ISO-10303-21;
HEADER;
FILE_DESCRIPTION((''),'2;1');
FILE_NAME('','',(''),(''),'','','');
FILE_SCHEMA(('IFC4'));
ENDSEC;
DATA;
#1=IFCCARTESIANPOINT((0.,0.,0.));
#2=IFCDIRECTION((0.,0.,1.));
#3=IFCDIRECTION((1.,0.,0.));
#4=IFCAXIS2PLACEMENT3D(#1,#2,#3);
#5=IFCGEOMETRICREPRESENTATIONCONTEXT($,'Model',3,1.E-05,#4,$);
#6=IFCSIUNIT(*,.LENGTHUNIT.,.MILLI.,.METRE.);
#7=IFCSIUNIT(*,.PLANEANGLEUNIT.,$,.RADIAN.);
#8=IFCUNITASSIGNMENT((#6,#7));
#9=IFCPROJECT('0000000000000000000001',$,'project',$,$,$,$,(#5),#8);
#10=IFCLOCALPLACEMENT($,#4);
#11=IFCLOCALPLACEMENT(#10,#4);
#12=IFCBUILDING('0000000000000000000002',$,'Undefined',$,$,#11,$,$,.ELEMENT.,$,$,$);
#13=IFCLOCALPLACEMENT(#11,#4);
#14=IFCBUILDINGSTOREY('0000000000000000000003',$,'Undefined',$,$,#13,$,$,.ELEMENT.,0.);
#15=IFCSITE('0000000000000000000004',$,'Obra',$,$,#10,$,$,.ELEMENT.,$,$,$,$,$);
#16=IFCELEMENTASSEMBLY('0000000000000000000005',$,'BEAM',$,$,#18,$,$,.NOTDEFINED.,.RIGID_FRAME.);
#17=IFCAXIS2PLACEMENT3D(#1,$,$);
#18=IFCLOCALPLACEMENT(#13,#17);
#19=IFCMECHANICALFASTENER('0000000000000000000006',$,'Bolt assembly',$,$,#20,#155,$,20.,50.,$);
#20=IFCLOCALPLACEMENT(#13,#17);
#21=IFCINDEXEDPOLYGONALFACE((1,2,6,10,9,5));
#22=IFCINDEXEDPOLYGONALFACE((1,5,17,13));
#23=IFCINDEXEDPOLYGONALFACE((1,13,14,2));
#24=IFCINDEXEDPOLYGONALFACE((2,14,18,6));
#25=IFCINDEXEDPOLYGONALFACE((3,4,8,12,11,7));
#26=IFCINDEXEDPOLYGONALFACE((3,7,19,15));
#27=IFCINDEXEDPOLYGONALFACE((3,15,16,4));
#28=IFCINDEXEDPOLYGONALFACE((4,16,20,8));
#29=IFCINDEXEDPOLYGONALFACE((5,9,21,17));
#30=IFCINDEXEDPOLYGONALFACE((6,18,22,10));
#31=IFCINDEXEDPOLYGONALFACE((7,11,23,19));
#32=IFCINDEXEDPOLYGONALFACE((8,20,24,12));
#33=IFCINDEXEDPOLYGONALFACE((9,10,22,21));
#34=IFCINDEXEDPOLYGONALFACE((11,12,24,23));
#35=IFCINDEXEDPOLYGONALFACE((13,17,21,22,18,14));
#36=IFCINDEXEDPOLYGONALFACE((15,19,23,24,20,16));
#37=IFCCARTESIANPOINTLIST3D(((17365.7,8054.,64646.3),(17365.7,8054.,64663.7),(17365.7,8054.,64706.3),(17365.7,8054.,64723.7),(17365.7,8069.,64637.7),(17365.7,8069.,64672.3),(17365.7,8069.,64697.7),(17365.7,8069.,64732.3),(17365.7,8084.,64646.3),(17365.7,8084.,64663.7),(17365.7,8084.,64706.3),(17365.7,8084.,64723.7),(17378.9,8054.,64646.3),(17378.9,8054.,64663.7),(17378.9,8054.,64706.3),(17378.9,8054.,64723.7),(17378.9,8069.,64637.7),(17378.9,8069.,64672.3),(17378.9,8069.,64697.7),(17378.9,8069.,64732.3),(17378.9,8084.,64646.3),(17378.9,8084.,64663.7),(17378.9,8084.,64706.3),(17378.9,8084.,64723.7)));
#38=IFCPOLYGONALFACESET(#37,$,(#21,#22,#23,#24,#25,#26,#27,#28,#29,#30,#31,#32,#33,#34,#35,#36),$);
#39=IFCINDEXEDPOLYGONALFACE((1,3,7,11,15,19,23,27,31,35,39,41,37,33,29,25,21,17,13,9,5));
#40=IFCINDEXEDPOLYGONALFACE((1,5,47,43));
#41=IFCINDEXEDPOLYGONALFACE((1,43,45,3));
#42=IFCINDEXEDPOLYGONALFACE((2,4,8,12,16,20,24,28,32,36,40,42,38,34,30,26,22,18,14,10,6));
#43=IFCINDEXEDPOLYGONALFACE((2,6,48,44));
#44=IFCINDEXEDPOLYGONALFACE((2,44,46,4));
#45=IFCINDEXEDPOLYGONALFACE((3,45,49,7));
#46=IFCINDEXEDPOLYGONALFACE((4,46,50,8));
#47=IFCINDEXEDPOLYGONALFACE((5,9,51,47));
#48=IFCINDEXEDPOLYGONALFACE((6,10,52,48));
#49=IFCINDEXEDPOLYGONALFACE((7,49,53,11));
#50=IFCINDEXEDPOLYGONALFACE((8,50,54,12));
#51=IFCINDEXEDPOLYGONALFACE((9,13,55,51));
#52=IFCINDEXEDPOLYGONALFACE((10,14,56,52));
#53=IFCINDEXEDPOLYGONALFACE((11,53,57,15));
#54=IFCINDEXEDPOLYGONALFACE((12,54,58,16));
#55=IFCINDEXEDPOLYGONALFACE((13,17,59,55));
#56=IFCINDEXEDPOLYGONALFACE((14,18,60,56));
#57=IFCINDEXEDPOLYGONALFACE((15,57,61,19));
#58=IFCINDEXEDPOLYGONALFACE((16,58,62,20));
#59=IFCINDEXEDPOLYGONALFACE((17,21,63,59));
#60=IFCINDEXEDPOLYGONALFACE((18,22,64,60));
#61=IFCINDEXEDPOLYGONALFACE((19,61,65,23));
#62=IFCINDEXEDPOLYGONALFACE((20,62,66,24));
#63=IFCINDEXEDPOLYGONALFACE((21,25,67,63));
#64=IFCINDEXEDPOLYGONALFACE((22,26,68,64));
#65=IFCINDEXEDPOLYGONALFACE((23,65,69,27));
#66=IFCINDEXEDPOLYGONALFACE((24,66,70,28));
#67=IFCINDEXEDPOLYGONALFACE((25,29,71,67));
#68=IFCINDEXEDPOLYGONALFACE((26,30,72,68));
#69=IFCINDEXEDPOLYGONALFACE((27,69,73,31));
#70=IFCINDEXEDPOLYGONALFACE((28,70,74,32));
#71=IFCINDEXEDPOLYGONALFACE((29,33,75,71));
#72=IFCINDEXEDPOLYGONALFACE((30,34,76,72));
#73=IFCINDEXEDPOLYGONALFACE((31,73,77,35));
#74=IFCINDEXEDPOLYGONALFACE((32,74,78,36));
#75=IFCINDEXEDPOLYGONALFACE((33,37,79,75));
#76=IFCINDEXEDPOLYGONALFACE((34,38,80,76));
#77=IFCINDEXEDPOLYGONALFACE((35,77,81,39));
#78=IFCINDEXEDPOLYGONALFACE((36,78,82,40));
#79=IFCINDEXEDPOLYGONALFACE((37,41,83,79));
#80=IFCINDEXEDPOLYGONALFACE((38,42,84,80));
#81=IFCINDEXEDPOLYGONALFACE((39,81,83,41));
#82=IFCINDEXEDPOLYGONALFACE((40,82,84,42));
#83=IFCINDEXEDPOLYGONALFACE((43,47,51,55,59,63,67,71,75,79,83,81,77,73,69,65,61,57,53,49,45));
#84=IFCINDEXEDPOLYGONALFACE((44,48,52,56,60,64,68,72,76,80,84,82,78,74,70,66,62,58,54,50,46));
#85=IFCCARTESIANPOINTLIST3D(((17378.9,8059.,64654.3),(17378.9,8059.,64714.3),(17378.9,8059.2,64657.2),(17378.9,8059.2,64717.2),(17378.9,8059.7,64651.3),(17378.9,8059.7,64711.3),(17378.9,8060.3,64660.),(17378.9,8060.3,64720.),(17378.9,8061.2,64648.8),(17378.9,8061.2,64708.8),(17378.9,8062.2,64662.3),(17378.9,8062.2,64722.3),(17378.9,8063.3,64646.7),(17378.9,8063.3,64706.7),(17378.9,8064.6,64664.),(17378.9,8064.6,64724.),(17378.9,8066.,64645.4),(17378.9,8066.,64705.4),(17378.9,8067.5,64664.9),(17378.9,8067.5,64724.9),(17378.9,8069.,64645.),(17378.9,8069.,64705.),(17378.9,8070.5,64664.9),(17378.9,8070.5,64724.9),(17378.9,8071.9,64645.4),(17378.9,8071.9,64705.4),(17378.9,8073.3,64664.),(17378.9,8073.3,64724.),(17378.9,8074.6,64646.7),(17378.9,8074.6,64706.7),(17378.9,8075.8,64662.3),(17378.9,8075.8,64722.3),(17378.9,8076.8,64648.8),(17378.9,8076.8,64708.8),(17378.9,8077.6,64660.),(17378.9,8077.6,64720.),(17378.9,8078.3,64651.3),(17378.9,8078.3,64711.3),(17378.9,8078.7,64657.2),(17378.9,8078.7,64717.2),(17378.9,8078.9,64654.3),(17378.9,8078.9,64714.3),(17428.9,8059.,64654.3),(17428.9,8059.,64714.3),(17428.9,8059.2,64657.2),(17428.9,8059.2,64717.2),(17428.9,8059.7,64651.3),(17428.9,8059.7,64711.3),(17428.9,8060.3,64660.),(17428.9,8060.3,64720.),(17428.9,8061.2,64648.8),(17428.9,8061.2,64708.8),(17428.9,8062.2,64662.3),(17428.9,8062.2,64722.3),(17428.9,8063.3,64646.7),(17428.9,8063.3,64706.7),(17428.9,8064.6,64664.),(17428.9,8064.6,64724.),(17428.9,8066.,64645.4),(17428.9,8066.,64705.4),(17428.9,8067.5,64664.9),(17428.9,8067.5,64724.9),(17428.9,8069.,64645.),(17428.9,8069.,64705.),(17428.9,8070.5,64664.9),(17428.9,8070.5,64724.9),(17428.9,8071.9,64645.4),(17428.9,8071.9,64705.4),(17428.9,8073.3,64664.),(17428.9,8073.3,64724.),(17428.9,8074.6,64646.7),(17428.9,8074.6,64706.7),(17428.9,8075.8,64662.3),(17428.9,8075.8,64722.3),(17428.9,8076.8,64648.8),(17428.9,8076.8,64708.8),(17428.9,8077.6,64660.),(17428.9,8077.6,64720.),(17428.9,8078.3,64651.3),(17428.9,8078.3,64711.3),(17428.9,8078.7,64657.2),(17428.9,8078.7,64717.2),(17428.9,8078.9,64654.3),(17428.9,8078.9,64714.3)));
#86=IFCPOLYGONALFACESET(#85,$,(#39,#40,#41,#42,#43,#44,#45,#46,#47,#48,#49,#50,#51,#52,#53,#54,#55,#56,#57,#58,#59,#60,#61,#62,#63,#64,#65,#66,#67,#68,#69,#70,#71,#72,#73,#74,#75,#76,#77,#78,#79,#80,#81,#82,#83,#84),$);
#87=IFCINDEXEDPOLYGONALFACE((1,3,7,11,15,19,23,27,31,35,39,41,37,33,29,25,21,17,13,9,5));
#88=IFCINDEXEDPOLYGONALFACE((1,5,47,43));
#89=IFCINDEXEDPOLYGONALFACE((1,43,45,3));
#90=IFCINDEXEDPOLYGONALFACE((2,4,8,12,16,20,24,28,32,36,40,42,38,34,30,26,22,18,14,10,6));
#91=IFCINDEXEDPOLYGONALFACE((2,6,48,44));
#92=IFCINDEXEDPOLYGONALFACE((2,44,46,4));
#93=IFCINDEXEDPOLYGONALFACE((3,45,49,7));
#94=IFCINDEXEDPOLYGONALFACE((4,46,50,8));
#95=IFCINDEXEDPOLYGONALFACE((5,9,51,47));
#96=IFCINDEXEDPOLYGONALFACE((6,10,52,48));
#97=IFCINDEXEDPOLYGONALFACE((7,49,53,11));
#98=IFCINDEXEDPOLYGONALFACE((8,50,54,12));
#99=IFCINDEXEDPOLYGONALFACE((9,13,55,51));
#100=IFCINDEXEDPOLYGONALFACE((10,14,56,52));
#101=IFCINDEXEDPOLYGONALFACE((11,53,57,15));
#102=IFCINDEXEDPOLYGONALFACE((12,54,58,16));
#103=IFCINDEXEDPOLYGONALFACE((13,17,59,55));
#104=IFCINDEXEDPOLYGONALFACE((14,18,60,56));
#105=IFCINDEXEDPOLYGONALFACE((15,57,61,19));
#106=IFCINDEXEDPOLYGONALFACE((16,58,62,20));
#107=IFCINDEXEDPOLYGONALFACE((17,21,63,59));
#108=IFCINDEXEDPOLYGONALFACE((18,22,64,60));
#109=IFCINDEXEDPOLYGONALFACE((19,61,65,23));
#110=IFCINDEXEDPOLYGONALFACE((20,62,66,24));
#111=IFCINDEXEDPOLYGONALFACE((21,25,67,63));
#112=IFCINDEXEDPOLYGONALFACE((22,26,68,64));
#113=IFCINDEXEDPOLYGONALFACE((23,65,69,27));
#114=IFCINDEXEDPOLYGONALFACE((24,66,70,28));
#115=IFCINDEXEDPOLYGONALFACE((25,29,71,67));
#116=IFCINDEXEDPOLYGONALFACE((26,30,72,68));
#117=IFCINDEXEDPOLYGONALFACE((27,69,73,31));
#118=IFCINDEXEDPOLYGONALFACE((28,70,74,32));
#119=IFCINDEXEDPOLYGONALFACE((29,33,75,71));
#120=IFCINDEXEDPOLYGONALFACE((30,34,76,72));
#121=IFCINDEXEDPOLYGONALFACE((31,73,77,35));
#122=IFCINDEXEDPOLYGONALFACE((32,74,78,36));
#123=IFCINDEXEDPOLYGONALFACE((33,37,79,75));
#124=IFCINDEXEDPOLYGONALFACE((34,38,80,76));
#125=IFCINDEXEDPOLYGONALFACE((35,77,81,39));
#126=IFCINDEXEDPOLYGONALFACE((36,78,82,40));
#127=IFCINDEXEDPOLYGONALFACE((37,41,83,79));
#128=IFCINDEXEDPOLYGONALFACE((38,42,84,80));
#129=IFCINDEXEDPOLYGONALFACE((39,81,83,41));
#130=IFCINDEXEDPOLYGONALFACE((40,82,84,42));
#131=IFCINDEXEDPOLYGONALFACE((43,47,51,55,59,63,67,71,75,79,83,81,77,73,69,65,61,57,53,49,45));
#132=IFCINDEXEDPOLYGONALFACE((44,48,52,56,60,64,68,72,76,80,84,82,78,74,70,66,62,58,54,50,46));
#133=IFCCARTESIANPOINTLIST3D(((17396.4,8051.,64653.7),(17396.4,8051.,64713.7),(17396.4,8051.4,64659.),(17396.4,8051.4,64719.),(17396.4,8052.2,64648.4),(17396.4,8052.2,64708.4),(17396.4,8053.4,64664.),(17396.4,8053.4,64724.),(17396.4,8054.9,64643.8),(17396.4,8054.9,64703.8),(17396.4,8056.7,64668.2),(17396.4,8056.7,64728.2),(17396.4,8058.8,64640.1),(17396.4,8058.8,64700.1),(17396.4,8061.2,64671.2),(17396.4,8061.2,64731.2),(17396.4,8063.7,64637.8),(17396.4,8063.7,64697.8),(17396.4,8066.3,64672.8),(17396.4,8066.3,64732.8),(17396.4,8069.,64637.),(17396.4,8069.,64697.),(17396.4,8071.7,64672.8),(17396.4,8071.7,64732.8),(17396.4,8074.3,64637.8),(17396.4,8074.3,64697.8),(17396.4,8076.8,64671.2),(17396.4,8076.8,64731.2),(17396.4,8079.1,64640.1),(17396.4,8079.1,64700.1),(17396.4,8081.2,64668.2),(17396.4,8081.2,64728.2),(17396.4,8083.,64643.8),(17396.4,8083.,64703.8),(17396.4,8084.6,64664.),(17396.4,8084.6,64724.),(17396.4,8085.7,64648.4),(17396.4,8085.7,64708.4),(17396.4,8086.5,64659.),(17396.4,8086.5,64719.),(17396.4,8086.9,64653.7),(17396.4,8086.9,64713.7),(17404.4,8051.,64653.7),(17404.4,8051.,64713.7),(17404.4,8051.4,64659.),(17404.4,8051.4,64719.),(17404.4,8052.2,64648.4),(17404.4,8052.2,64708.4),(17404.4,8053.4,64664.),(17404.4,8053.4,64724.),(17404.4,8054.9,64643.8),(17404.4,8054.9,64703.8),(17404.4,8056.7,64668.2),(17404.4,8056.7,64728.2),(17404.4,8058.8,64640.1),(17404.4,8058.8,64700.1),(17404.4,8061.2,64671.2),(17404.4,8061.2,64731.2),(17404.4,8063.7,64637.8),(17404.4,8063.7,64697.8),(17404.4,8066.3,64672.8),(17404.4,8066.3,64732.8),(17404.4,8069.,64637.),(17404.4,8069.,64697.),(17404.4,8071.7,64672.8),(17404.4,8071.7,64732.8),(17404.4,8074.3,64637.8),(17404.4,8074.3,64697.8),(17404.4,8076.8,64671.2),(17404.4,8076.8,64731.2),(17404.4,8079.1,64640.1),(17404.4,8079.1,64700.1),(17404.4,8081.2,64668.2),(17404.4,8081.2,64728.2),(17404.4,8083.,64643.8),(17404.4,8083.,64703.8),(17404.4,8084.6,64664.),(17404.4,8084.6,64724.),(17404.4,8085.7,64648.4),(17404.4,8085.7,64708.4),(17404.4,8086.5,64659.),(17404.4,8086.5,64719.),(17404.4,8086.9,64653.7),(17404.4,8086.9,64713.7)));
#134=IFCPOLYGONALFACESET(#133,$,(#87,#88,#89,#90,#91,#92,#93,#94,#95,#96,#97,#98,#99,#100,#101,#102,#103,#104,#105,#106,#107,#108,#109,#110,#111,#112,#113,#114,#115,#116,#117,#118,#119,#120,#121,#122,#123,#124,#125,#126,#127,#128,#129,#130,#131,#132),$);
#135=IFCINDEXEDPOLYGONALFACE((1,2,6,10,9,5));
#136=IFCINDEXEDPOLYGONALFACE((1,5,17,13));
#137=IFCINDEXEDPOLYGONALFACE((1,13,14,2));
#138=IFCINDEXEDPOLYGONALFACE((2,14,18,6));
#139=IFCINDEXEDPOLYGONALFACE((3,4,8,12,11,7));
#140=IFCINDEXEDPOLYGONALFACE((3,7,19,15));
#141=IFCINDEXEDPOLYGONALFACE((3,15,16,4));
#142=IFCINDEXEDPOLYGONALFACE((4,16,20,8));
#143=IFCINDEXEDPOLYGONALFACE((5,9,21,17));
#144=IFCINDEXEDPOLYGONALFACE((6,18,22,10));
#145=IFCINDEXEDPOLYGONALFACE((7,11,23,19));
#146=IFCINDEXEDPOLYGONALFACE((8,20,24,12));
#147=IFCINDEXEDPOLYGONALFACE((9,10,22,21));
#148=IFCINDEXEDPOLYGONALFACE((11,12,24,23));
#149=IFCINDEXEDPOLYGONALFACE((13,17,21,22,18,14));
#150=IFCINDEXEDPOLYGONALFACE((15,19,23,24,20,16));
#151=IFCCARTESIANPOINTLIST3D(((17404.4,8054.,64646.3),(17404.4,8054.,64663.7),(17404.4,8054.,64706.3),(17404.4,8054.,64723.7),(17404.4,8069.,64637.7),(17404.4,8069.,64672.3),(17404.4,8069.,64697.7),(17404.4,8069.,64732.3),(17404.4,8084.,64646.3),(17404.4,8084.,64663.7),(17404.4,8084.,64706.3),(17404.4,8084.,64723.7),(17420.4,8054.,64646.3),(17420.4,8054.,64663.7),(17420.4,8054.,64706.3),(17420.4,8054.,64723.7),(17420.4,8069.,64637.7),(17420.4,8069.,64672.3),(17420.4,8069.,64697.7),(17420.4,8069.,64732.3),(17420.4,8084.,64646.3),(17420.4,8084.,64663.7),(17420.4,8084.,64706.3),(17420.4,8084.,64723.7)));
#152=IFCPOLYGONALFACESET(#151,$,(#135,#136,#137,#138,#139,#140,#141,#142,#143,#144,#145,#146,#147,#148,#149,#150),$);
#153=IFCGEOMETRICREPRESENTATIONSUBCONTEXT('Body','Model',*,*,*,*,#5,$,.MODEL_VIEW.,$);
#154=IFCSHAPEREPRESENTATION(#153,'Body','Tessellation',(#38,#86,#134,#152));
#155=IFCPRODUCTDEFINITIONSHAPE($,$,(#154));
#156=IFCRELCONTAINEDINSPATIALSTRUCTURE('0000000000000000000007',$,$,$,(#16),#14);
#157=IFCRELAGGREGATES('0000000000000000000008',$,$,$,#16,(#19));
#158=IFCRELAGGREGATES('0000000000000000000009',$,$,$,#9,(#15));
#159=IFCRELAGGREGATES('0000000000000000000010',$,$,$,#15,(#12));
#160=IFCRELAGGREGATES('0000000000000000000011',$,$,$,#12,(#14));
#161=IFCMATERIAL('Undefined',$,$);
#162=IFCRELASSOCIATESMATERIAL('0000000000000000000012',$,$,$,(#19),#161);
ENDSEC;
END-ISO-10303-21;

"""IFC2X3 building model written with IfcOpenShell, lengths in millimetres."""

from ifc_helpers import new_model, si_unit, frame, origin_with_axes, origin_2d_with_axis, place, context, subcontext, project, spatial, polyline, circle, outline, extrude, source, transform, mapped, material, element, aggregate, save


model = new_model("IFC2X3")

# Units and contexts
model_context = context("Model", 3, precision=1e-05, world=origin_with_axes())
body_context = subcontext(model_context, "Body", "Model", "MODEL_VIEW")
ifc_project = project(units=[si_unit("LENGTHUNIT", "METRE", prefix="MILLI"), si_unit("PLANEANGLEUNIT", "RADIAN")], contexts=[model_context])

# Site, building, storey
site_placement = place(None, origin_with_axes())
site = spatial("IfcSite", under=ifc_project, at=site_placement, Name="Obra", CompositionType="ELEMENT")
building_placement = place(site_placement, origin_with_axes())
building = spatial("IfcBuilding", under=site, at=building_placement, Name="Undefined", CompositionType="ELEMENT")
storey_placement = place(building_placement, origin_with_axes())
storey = spatial("IfcBuildingStorey", under=building, at=storey_placement, Name="Undefined", CompositionType="ELEMENT", Elevation=0.0)

# Shared definitions
ifc_material = material(Name="Undefined")

# Element assembly, mechanical fastener
shared_shape_1 = source(origin_with_axes(), body_context, "Body", "SweptSolid", [
    extrude(outline(polyline([(17.3, 0.0), (8.7, 15.0), (-8.7, 15.0), (-17.3, 0.0), (-8.7, -15.0), (8.7, -15.0), (17.3, 0.0)])), frame((0.0, -27.0, 0.0), z_axis=(0.0, 1.0, 0.0), x_axis=(1.0, 0.0, 0.0)), (0.0, 0.0, 1.0), 13.2),
    extrude(circle(Radius=10.0, at=origin_2d_with_axis()), frame((0.0, -13.8, 0.0), z_axis=(0.0, 1.0, 0.0), x_axis=(1.0, 0.0, 0.0)), (0.0, 0.0, 1.0), 50.0),
    extrude(circle(Radius=18.0, at=origin_2d_with_axis()), frame((0.0, 3.7, 0.0), z_axis=(0.0, 1.0, 0.0), x_axis=(1.0, 0.0, 0.0)), (0.0, 0.0, 1.0), 8.0),
    extrude(outline(polyline([(17.3, 0.0), (8.7, 15.0), (-8.7, 15.0), (-17.3, 0.0), (-8.7, -15.0), (8.7, -15.0), (17.3, 0.0)])), frame((0.0, 11.7, 0.0), z_axis=(0.0, 1.0, 0.0), x_axis=(1.0, 0.0, 0.0)), (0.0, 0.0, 1.0), 16.0),
])
assembly_1_placement = place(storey_placement, origin_with_axes())
assembly_1 = element("IfcElementAssembly", 1, at=assembly_1_placement, inside=storey, Name="BEAM", AssemblyPlace="NOTDEFINED", PredefinedType="RIGID_FRAME")
mechanical_fastener_1_placement = place(assembly_1_placement, frame((17392.7, 8109.0, 64850.0), z_axis=(0.0, -1.0, 0.0), x_axis=(0.0, 0.0, -1.0)))
mechanical_fastener_1 = element("IfcMechanicalFastener", 2, at=mechanical_fastener_1_placement, material=ifc_material, Name="Bolt assembly", NominalDiameter=20.0, NominalLength=50.0, context=body_context, shape_type="MappedRepresentation", body=[
    mapped(shared_shape_1, transform((135.0, 0.0, 40.0))),
    mapped(shared_shape_1, transform((195.0, 0.0, 40.0))),
])

aggregate(assembly_1, [mechanical_fastener_1])

save(model, "model.ifc")
